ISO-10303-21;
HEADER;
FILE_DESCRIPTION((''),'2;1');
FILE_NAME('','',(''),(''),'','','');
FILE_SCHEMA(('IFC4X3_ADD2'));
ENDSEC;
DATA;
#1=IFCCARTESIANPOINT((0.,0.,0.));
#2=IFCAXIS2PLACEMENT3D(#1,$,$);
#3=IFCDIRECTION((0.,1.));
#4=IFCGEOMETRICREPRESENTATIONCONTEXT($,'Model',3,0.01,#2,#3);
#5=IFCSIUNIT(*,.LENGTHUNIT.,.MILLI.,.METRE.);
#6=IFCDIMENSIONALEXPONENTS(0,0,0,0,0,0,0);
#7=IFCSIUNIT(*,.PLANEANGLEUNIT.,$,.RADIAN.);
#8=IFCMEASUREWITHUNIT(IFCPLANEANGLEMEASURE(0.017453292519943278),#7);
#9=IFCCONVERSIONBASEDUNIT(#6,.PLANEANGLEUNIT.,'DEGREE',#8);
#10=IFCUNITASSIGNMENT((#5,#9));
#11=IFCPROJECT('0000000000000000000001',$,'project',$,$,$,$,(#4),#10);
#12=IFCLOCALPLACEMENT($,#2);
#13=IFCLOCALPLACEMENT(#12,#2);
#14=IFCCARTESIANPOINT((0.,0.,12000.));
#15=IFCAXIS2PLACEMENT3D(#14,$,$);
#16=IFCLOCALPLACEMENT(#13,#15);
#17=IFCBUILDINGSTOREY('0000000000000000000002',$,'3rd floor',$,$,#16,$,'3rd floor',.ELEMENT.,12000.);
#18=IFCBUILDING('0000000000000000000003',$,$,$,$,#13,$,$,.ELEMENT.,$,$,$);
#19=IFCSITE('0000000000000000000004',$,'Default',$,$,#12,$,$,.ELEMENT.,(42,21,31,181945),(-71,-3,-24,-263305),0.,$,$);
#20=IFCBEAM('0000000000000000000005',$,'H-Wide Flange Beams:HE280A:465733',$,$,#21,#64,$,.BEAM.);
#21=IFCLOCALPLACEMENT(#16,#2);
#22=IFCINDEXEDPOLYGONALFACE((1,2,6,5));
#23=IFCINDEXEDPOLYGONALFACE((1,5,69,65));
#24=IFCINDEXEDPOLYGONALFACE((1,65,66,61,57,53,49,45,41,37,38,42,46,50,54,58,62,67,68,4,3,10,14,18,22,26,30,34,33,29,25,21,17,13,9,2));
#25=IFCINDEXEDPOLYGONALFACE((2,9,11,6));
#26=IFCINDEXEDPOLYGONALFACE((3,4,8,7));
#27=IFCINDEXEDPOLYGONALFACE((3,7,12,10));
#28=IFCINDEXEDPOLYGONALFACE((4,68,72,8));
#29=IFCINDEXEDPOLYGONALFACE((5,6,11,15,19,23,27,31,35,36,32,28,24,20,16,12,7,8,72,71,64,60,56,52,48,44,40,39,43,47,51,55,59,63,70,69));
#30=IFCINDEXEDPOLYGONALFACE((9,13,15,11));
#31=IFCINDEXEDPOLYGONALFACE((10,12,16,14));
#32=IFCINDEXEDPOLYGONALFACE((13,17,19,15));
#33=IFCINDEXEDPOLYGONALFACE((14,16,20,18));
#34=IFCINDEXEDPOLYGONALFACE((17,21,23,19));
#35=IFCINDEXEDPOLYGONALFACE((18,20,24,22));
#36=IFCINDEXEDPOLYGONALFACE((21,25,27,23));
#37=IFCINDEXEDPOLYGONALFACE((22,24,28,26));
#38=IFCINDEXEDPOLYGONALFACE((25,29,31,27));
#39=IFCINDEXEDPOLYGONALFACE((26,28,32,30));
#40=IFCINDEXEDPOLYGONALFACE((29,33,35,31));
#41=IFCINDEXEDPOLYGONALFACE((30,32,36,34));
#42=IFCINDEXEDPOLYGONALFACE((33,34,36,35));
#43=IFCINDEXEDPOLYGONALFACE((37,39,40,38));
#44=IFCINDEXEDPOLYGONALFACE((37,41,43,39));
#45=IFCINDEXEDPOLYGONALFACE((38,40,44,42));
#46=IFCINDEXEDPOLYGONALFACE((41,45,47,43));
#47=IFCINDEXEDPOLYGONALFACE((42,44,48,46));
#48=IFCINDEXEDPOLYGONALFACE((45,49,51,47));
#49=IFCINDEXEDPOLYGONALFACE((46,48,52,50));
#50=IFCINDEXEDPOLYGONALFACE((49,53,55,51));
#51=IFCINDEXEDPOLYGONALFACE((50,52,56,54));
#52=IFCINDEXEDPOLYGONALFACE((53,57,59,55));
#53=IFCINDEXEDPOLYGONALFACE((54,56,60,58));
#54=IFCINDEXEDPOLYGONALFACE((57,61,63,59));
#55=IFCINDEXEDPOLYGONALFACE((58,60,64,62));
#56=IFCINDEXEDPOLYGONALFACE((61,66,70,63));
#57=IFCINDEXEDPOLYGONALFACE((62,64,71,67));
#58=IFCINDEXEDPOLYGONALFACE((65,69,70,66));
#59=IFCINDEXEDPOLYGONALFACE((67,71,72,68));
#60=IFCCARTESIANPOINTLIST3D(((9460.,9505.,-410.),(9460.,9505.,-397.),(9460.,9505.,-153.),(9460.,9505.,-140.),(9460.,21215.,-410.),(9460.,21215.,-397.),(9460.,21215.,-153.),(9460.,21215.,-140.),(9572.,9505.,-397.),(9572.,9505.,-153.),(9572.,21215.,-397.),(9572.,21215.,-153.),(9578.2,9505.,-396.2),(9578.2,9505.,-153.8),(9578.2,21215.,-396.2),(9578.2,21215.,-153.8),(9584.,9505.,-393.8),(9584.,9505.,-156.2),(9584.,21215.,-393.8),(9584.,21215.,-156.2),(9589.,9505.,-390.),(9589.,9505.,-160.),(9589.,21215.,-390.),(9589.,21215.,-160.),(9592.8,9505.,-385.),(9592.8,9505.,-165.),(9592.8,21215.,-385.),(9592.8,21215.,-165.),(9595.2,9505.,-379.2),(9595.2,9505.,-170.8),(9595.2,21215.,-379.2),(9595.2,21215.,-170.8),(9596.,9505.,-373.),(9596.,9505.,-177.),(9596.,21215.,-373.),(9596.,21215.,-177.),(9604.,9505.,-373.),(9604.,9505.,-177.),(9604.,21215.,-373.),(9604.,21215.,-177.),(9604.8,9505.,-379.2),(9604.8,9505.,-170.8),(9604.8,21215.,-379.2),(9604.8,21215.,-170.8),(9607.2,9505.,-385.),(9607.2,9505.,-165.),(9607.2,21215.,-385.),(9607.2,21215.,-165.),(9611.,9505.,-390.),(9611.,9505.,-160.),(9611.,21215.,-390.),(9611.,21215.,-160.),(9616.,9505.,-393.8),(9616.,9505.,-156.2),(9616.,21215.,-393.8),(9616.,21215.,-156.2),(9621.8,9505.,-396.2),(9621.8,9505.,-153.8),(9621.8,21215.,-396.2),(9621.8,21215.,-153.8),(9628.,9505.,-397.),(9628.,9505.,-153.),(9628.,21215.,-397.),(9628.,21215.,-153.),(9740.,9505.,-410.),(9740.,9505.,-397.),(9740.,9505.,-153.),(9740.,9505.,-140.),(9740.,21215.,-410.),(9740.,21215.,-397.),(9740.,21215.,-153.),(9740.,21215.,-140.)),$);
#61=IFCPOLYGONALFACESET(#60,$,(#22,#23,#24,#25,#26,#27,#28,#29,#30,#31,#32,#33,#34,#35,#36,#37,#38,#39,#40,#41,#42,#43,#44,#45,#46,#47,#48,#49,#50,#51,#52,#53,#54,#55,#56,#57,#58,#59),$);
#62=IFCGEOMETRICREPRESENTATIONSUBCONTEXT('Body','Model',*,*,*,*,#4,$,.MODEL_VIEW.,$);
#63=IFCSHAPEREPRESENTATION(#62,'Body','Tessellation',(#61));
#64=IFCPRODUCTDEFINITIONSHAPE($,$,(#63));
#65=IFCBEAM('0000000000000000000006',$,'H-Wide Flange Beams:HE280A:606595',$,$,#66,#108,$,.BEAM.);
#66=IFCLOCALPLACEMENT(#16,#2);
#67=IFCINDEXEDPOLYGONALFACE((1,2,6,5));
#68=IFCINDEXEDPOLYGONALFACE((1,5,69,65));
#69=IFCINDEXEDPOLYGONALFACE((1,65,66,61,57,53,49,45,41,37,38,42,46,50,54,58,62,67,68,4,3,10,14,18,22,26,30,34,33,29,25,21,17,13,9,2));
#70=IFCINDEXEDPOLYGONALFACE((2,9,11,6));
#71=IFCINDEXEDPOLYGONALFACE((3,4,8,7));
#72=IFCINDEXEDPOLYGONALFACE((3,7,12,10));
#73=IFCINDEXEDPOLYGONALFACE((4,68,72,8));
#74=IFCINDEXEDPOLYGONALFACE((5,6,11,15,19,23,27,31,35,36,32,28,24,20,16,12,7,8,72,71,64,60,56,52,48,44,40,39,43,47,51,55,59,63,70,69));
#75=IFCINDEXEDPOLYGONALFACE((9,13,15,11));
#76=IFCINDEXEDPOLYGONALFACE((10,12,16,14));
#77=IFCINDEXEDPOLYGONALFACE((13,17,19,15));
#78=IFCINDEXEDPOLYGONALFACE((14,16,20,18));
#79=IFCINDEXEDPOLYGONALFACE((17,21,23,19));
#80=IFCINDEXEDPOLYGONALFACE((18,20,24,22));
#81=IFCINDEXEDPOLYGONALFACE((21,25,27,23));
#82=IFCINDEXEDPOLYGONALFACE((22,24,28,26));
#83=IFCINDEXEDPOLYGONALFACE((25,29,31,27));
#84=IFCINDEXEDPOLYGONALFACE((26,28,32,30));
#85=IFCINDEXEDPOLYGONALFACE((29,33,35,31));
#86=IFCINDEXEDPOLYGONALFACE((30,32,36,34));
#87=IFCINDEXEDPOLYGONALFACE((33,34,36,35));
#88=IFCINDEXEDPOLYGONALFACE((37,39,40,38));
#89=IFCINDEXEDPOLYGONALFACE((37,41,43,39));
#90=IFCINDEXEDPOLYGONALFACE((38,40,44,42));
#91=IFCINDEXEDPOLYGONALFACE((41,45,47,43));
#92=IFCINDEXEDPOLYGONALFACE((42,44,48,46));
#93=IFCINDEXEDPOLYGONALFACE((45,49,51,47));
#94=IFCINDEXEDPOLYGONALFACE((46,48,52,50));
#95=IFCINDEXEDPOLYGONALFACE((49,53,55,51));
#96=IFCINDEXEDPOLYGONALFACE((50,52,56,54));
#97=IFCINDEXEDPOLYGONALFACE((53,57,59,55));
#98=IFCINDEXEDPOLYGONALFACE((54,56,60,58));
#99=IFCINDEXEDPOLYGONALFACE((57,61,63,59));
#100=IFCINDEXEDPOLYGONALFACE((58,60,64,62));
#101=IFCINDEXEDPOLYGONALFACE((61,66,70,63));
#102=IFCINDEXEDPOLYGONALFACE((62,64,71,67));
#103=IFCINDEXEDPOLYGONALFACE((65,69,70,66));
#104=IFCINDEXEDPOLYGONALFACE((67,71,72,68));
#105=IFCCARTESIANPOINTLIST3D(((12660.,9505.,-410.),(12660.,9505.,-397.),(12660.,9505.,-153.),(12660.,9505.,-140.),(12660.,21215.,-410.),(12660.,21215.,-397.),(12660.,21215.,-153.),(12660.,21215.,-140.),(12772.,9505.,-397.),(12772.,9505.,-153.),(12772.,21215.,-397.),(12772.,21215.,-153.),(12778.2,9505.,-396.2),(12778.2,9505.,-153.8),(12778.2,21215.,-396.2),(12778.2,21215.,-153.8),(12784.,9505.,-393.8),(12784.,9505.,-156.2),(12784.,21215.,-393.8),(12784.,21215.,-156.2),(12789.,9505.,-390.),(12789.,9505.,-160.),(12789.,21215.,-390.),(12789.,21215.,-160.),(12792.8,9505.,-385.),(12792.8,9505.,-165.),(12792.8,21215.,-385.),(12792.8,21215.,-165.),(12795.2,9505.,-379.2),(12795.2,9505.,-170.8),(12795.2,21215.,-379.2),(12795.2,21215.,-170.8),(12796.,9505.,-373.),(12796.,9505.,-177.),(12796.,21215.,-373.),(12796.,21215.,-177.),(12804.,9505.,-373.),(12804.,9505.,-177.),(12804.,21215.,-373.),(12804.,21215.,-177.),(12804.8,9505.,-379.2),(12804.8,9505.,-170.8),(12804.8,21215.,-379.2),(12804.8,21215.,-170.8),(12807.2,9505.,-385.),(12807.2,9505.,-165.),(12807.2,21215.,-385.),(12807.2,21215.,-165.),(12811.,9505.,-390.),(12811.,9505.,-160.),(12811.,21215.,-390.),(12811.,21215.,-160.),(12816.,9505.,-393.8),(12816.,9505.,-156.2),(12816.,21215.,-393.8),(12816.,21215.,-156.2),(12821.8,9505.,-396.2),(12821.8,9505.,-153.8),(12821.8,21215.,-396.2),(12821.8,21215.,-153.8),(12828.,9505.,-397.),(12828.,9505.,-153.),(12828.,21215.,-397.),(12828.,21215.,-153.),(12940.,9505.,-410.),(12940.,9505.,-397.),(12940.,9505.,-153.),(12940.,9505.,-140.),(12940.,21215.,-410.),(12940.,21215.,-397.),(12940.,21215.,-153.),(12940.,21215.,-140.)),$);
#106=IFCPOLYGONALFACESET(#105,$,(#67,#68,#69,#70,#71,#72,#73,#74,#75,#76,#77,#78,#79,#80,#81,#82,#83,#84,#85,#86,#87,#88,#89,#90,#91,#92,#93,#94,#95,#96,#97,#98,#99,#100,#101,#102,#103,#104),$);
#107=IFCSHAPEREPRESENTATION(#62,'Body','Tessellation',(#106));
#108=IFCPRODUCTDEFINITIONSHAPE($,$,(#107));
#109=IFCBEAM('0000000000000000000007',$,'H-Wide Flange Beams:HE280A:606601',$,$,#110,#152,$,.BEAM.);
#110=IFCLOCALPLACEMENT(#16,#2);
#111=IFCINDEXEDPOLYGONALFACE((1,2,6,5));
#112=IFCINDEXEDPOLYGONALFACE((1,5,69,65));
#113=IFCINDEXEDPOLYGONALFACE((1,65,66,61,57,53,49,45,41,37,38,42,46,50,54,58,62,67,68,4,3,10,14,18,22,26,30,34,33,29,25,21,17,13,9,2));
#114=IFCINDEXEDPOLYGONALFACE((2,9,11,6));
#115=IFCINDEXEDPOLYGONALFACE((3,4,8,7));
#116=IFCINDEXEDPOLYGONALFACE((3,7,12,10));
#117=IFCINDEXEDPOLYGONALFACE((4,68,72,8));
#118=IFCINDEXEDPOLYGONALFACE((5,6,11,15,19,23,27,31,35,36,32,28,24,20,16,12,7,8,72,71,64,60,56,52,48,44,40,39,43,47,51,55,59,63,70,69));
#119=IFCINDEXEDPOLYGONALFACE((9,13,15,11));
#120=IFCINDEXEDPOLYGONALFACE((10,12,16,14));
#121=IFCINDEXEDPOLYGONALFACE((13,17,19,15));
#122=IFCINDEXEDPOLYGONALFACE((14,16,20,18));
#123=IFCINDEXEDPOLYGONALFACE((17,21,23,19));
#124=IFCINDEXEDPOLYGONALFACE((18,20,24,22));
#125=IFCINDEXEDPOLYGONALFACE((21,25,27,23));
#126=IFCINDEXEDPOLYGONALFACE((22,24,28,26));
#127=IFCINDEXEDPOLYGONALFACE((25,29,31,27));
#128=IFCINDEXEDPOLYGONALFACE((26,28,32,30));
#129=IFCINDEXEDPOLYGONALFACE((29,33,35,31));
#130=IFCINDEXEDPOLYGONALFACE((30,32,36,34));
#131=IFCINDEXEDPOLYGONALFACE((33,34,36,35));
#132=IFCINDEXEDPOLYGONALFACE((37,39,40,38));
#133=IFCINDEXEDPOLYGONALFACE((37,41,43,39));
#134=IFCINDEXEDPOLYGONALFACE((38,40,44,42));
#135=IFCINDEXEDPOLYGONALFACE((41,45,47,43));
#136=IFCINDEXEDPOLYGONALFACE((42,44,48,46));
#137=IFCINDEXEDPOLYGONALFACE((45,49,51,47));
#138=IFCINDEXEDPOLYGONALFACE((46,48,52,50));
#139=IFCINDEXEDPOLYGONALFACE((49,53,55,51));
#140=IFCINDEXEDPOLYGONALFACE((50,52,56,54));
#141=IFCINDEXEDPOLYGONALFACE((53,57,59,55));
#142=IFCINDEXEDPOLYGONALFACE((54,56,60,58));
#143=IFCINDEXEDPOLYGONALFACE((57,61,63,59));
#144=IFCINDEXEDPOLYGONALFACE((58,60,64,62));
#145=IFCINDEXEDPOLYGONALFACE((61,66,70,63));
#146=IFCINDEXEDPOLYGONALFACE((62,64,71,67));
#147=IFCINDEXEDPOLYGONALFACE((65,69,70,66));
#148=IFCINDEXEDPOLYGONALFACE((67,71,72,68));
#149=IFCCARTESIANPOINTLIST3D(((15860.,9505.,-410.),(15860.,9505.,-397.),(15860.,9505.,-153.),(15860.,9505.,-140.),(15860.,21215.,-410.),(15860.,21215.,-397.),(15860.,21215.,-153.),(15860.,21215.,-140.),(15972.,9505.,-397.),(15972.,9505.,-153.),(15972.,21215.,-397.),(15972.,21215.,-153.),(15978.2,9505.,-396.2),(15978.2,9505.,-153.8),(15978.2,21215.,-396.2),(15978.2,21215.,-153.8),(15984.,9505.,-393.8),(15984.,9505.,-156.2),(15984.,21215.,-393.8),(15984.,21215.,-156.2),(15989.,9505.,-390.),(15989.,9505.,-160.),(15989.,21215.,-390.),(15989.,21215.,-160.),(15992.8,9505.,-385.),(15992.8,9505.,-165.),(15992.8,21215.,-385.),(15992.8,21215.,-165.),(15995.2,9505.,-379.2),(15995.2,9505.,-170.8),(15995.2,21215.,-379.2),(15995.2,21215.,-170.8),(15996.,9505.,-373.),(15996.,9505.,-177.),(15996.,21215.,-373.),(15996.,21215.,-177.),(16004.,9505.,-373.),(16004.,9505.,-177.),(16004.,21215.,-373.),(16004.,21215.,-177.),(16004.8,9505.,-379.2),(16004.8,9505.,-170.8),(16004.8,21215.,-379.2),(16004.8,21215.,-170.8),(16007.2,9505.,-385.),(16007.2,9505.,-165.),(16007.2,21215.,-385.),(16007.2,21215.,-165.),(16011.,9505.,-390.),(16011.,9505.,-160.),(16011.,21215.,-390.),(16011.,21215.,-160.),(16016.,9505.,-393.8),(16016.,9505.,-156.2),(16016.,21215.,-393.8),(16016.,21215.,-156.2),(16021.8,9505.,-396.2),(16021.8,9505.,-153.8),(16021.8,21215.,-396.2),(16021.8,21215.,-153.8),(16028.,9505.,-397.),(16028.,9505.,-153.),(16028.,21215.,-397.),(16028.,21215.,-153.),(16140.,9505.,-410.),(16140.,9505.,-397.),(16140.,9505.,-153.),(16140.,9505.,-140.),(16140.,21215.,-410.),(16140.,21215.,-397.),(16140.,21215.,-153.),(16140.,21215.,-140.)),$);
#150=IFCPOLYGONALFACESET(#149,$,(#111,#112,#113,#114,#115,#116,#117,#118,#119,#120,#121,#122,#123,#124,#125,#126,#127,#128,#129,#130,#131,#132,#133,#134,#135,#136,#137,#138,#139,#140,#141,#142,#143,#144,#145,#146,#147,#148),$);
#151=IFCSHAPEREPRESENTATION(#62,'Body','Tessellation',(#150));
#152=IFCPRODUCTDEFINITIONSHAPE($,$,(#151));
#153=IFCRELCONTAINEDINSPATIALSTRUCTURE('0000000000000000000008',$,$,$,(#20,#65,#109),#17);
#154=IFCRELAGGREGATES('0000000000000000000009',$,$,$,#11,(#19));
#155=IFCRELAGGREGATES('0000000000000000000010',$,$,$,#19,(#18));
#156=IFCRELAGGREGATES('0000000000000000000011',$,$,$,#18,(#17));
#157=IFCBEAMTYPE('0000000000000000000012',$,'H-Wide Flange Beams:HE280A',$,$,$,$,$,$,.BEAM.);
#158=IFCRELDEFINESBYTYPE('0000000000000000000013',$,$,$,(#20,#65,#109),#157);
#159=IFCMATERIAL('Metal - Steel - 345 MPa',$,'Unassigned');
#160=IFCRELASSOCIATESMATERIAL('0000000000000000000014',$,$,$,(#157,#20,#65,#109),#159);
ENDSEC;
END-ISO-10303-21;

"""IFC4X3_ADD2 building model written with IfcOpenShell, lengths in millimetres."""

from ifc_helpers import new_model, entity, si_unit, converted_unit, direction, frame, frame_2d, origin, place, context, subcontext, project, spatial, polyline, circle_curve, parameter, trimmed, segment, composite_curve, outline, extrude, source, transform, mapped, material, material_profile, profile_set, profile_usage, type_object, type_shapes, element, save


model = new_model("IFC4X3_ADD2")

# Units and contexts
model_context = context("Model", 3, precision=0.01, world=origin(), true_north=direction((0.0, 1.0)))
body_context = subcontext(model_context, "Body", "Model", "MODEL_VIEW")
ifc_project = project(units=[si_unit("LENGTHUNIT", "METRE", prefix="MILLI"), converted_unit("PLANEANGLEUNIT", "DEGREE", entity("IfcPlaneAngleMeasure", 0.017453292519943278), si_unit("PLANEANGLEUNIT", "RADIAN"), dimensions=[0, 0, 0, 0, 0, 0, 0])], contexts=[model_context])

# Site, building, storey
site_placement = place(None, origin())
site = spatial("IfcSite", under=ifc_project, at=site_placement, Name="Default", CompositionType="ELEMENT", RefLatitude=(42, 21, 31, 181945), RefLongitude=(-71, -3, -24, -263305), RefElevation=0.0)
building_placement = place(site_placement, origin())
building = spatial("IfcBuilding", under=site, at=building_placement, CompositionType="ELEMENT")
storey_placement = place(building_placement, frame((0.0, 0.0, 12000.0)))
storey = spatial("IfcBuildingStorey", under=building, at=storey_placement, Name="3rd floor", LongName="3rd floor", CompositionType="ELEMENT", Elevation=12000.0)

# Beams
ifc_material_1 = material(Name="Metal - Steel - 345 MPa", Category="Unassigned")
ifc_material_profile_1 = material_profile(ifc_material_1, outline(composite_curve([segment(polyline([(-140.0, -122.0), (-140.0, -135.0)]), True, "CONTINUOUS"), segment(polyline([(-140.0, -135.0), (140.0, -135.0)]), True, "CONTINUOUS"), segment(polyline([(140.0, -135.0), (140.0, -122.0)]), True, "CONTINUOUS"), segment(polyline([(140.0, -122.0), (28.0, -122.0)]), True, "CONTINUOUS"), segment(trimmed(circle_curve(frame_2d((28.0, -98.0), x_axis=(1.0, 0.0)), 24.0), [parameter(180.0)], [parameter(270.0)], True, "PARAMETER"), False, "CONTINUOUS"), segment(polyline([(4.0, -98.0), (4.0, 98.0)]), True, "CONTINUOUS"), segment(trimmed(circle_curve(frame_2d((28.0, 98.0), x_axis=(1.0, 0.0)), 24.0), [parameter(90.0)], [parameter(180.0)], True, "PARAMETER"), False, "CONTINUOUS"), segment(polyline([(28.0, 122.0), (140.0, 122.0)]), True, "CONTINUOUS"), segment(polyline([(140.0, 122.0), (140.0, 135.0)]), True, "CONTINUOUS"), segment(polyline([(140.0, 135.0), (-140.0, 135.0)]), True, "CONTINUOUS"), segment(polyline([(-140.0, 135.0), (-140.0, 122.0)]), True, "CONTINUOUS"), segment(polyline([(-140.0, 122.0), (-28.0, 122.0)]), True, "CONTINUOUS"), segment(trimmed(circle_curve(frame_2d((-28.0, 98.0), x_axis=(1.0, 0.0)), 24.0), [parameter(360.0)], [parameter(90.0)], True, "PARAMETER"), False, "CONTINUOUS"), segment(polyline([(-4.0, 98.0), (-4.0, -98.0)]), True, "CONTINUOUS"), segment(trimmed(circle_curve(frame_2d((-28.0, -98.0), x_axis=(1.0, 0.0)), 24.0), [parameter(270.0)], [parameter(360.0)], True, "PARAMETER"), False, "CONTINUOUS"), segment(polyline([(-28.0, -122.0), (-140.0, -122.0)]), True, "CONTINUOUS")], self_intersect=False)), Name="HE280A")
ifc_profile_set_1 = profile_set([ifc_material_profile_1], Name="HE280A")
ifc_profile_usage_1 = profile_usage(ifc_profile_set_1, cardinal=8)
beam_type_1 = type_object("IfcBeamType", Name="H-Wide Flange Beams:HE280A", PredefinedType="BEAM", material=ifc_profile_set_1)
shared_shape_1 = source(origin(), body_context, "Body", "SweptSolid", [
    extrude(outline(composite_curve([segment(polyline([(-140.0, -122.0), (-140.0, -135.0)]), True, "CONTINUOUS"), segment(polyline([(-140.0, -135.0), (140.0, -135.0)]), True, "CONTINUOUS"), segment(polyline([(140.0, -135.0), (140.0, -122.0)]), True, "CONTINUOUS"), segment(polyline([(140.0, -122.0), (28.0, -122.0)]), True, "CONTINUOUS"), segment(trimmed(circle_curve(frame_2d((28.0, -98.0), x_axis=(1.0, 0.0)), 24.0), [parameter(180.0)], [parameter(270.0)], True, "PARAMETER"), False, "CONTINUOUS"), segment(polyline([(4.0, -98.0), (4.0, 98.0)]), True, "CONTINUOUS"), segment(trimmed(circle_curve(frame_2d((28.0, 98.0), x_axis=(1.0, 0.0)), 24.0), [parameter(90.0)], [parameter(180.0)], True, "PARAMETER"), False, "CONTINUOUS"), segment(polyline([(28.0, 122.0), (140.0, 122.0)]), True, "CONTINUOUS"), segment(polyline([(140.0, 122.0), (140.0, 135.0)]), True, "CONTINUOUS"), segment(polyline([(140.0, 135.0), (-140.0, 135.0)]), True, "CONTINUOUS"), segment(polyline([(-140.0, 135.0), (-140.0, 122.0)]), True, "CONTINUOUS"), segment(polyline([(-140.0, 122.0), (-28.0, 122.0)]), True, "CONTINUOUS"), segment(trimmed(circle_curve(frame_2d((-28.0, 98.0), x_axis=(1.0, 0.0)), 24.0), [parameter(360.0)], [parameter(90.0)], True, "PARAMETER"), False, "CONTINUOUS"), segment(polyline([(-4.0, 98.0), (-4.0, -98.0)]), True, "CONTINUOUS"), segment(trimmed(circle_curve(frame_2d((-28.0, -98.0), x_axis=(1.0, 0.0)), 24.0), [parameter(270.0)], [parameter(360.0)], True, "PARAMETER"), False, "CONTINUOUS"), segment(polyline([(-28.0, -122.0), (-140.0, -122.0)]), True, "CONTINUOUS")], self_intersect=False)), frame((-4255.0, 0.0, 0.0), z_axis=(-1.0, 0.0, 0.0), x_axis=(0.0, -1.0, 0.0)), (0.0, 0.0, -1.0), 11710.0),
])
type_shapes(beam_type_1, [shared_shape_1])
for number, where, z_axis, x_axis, name in (
    (1, (9600.0, 16960.0, -275.0), (0.0, 0.0, 1.0), (0.0, -1.0, 0.0), "H-Wide Flange Beams:HE280A:465733"),
    (2, (12800.0, 16960.0, -275.0), (0.0, 0.0, 1.0), (0.0, -1.0, 0.0), "H-Wide Flange Beams:HE280A:606595"),
    (3, (16000.0, 16960.0, -275.0), (0.0, 0.0, 1.0), (0.0, -1.0, 0.0), "H-Wide Flange Beams:HE280A:606601"),
):
    element("IfcBeam", number, at=place(storey_placement, frame(where, z_axis=z_axis, x_axis=x_axis)), inside=storey, type_object=beam_type_1, material=ifc_profile_usage_1, Name=name, PredefinedType="BEAM", context=body_context, shape_type="MappedRepresentation", body=[
        mapped(shared_shape_1, transform((0.0, 0.0, 0.0), scale=1.0)),
    ])

save(model, "model.ifc")
